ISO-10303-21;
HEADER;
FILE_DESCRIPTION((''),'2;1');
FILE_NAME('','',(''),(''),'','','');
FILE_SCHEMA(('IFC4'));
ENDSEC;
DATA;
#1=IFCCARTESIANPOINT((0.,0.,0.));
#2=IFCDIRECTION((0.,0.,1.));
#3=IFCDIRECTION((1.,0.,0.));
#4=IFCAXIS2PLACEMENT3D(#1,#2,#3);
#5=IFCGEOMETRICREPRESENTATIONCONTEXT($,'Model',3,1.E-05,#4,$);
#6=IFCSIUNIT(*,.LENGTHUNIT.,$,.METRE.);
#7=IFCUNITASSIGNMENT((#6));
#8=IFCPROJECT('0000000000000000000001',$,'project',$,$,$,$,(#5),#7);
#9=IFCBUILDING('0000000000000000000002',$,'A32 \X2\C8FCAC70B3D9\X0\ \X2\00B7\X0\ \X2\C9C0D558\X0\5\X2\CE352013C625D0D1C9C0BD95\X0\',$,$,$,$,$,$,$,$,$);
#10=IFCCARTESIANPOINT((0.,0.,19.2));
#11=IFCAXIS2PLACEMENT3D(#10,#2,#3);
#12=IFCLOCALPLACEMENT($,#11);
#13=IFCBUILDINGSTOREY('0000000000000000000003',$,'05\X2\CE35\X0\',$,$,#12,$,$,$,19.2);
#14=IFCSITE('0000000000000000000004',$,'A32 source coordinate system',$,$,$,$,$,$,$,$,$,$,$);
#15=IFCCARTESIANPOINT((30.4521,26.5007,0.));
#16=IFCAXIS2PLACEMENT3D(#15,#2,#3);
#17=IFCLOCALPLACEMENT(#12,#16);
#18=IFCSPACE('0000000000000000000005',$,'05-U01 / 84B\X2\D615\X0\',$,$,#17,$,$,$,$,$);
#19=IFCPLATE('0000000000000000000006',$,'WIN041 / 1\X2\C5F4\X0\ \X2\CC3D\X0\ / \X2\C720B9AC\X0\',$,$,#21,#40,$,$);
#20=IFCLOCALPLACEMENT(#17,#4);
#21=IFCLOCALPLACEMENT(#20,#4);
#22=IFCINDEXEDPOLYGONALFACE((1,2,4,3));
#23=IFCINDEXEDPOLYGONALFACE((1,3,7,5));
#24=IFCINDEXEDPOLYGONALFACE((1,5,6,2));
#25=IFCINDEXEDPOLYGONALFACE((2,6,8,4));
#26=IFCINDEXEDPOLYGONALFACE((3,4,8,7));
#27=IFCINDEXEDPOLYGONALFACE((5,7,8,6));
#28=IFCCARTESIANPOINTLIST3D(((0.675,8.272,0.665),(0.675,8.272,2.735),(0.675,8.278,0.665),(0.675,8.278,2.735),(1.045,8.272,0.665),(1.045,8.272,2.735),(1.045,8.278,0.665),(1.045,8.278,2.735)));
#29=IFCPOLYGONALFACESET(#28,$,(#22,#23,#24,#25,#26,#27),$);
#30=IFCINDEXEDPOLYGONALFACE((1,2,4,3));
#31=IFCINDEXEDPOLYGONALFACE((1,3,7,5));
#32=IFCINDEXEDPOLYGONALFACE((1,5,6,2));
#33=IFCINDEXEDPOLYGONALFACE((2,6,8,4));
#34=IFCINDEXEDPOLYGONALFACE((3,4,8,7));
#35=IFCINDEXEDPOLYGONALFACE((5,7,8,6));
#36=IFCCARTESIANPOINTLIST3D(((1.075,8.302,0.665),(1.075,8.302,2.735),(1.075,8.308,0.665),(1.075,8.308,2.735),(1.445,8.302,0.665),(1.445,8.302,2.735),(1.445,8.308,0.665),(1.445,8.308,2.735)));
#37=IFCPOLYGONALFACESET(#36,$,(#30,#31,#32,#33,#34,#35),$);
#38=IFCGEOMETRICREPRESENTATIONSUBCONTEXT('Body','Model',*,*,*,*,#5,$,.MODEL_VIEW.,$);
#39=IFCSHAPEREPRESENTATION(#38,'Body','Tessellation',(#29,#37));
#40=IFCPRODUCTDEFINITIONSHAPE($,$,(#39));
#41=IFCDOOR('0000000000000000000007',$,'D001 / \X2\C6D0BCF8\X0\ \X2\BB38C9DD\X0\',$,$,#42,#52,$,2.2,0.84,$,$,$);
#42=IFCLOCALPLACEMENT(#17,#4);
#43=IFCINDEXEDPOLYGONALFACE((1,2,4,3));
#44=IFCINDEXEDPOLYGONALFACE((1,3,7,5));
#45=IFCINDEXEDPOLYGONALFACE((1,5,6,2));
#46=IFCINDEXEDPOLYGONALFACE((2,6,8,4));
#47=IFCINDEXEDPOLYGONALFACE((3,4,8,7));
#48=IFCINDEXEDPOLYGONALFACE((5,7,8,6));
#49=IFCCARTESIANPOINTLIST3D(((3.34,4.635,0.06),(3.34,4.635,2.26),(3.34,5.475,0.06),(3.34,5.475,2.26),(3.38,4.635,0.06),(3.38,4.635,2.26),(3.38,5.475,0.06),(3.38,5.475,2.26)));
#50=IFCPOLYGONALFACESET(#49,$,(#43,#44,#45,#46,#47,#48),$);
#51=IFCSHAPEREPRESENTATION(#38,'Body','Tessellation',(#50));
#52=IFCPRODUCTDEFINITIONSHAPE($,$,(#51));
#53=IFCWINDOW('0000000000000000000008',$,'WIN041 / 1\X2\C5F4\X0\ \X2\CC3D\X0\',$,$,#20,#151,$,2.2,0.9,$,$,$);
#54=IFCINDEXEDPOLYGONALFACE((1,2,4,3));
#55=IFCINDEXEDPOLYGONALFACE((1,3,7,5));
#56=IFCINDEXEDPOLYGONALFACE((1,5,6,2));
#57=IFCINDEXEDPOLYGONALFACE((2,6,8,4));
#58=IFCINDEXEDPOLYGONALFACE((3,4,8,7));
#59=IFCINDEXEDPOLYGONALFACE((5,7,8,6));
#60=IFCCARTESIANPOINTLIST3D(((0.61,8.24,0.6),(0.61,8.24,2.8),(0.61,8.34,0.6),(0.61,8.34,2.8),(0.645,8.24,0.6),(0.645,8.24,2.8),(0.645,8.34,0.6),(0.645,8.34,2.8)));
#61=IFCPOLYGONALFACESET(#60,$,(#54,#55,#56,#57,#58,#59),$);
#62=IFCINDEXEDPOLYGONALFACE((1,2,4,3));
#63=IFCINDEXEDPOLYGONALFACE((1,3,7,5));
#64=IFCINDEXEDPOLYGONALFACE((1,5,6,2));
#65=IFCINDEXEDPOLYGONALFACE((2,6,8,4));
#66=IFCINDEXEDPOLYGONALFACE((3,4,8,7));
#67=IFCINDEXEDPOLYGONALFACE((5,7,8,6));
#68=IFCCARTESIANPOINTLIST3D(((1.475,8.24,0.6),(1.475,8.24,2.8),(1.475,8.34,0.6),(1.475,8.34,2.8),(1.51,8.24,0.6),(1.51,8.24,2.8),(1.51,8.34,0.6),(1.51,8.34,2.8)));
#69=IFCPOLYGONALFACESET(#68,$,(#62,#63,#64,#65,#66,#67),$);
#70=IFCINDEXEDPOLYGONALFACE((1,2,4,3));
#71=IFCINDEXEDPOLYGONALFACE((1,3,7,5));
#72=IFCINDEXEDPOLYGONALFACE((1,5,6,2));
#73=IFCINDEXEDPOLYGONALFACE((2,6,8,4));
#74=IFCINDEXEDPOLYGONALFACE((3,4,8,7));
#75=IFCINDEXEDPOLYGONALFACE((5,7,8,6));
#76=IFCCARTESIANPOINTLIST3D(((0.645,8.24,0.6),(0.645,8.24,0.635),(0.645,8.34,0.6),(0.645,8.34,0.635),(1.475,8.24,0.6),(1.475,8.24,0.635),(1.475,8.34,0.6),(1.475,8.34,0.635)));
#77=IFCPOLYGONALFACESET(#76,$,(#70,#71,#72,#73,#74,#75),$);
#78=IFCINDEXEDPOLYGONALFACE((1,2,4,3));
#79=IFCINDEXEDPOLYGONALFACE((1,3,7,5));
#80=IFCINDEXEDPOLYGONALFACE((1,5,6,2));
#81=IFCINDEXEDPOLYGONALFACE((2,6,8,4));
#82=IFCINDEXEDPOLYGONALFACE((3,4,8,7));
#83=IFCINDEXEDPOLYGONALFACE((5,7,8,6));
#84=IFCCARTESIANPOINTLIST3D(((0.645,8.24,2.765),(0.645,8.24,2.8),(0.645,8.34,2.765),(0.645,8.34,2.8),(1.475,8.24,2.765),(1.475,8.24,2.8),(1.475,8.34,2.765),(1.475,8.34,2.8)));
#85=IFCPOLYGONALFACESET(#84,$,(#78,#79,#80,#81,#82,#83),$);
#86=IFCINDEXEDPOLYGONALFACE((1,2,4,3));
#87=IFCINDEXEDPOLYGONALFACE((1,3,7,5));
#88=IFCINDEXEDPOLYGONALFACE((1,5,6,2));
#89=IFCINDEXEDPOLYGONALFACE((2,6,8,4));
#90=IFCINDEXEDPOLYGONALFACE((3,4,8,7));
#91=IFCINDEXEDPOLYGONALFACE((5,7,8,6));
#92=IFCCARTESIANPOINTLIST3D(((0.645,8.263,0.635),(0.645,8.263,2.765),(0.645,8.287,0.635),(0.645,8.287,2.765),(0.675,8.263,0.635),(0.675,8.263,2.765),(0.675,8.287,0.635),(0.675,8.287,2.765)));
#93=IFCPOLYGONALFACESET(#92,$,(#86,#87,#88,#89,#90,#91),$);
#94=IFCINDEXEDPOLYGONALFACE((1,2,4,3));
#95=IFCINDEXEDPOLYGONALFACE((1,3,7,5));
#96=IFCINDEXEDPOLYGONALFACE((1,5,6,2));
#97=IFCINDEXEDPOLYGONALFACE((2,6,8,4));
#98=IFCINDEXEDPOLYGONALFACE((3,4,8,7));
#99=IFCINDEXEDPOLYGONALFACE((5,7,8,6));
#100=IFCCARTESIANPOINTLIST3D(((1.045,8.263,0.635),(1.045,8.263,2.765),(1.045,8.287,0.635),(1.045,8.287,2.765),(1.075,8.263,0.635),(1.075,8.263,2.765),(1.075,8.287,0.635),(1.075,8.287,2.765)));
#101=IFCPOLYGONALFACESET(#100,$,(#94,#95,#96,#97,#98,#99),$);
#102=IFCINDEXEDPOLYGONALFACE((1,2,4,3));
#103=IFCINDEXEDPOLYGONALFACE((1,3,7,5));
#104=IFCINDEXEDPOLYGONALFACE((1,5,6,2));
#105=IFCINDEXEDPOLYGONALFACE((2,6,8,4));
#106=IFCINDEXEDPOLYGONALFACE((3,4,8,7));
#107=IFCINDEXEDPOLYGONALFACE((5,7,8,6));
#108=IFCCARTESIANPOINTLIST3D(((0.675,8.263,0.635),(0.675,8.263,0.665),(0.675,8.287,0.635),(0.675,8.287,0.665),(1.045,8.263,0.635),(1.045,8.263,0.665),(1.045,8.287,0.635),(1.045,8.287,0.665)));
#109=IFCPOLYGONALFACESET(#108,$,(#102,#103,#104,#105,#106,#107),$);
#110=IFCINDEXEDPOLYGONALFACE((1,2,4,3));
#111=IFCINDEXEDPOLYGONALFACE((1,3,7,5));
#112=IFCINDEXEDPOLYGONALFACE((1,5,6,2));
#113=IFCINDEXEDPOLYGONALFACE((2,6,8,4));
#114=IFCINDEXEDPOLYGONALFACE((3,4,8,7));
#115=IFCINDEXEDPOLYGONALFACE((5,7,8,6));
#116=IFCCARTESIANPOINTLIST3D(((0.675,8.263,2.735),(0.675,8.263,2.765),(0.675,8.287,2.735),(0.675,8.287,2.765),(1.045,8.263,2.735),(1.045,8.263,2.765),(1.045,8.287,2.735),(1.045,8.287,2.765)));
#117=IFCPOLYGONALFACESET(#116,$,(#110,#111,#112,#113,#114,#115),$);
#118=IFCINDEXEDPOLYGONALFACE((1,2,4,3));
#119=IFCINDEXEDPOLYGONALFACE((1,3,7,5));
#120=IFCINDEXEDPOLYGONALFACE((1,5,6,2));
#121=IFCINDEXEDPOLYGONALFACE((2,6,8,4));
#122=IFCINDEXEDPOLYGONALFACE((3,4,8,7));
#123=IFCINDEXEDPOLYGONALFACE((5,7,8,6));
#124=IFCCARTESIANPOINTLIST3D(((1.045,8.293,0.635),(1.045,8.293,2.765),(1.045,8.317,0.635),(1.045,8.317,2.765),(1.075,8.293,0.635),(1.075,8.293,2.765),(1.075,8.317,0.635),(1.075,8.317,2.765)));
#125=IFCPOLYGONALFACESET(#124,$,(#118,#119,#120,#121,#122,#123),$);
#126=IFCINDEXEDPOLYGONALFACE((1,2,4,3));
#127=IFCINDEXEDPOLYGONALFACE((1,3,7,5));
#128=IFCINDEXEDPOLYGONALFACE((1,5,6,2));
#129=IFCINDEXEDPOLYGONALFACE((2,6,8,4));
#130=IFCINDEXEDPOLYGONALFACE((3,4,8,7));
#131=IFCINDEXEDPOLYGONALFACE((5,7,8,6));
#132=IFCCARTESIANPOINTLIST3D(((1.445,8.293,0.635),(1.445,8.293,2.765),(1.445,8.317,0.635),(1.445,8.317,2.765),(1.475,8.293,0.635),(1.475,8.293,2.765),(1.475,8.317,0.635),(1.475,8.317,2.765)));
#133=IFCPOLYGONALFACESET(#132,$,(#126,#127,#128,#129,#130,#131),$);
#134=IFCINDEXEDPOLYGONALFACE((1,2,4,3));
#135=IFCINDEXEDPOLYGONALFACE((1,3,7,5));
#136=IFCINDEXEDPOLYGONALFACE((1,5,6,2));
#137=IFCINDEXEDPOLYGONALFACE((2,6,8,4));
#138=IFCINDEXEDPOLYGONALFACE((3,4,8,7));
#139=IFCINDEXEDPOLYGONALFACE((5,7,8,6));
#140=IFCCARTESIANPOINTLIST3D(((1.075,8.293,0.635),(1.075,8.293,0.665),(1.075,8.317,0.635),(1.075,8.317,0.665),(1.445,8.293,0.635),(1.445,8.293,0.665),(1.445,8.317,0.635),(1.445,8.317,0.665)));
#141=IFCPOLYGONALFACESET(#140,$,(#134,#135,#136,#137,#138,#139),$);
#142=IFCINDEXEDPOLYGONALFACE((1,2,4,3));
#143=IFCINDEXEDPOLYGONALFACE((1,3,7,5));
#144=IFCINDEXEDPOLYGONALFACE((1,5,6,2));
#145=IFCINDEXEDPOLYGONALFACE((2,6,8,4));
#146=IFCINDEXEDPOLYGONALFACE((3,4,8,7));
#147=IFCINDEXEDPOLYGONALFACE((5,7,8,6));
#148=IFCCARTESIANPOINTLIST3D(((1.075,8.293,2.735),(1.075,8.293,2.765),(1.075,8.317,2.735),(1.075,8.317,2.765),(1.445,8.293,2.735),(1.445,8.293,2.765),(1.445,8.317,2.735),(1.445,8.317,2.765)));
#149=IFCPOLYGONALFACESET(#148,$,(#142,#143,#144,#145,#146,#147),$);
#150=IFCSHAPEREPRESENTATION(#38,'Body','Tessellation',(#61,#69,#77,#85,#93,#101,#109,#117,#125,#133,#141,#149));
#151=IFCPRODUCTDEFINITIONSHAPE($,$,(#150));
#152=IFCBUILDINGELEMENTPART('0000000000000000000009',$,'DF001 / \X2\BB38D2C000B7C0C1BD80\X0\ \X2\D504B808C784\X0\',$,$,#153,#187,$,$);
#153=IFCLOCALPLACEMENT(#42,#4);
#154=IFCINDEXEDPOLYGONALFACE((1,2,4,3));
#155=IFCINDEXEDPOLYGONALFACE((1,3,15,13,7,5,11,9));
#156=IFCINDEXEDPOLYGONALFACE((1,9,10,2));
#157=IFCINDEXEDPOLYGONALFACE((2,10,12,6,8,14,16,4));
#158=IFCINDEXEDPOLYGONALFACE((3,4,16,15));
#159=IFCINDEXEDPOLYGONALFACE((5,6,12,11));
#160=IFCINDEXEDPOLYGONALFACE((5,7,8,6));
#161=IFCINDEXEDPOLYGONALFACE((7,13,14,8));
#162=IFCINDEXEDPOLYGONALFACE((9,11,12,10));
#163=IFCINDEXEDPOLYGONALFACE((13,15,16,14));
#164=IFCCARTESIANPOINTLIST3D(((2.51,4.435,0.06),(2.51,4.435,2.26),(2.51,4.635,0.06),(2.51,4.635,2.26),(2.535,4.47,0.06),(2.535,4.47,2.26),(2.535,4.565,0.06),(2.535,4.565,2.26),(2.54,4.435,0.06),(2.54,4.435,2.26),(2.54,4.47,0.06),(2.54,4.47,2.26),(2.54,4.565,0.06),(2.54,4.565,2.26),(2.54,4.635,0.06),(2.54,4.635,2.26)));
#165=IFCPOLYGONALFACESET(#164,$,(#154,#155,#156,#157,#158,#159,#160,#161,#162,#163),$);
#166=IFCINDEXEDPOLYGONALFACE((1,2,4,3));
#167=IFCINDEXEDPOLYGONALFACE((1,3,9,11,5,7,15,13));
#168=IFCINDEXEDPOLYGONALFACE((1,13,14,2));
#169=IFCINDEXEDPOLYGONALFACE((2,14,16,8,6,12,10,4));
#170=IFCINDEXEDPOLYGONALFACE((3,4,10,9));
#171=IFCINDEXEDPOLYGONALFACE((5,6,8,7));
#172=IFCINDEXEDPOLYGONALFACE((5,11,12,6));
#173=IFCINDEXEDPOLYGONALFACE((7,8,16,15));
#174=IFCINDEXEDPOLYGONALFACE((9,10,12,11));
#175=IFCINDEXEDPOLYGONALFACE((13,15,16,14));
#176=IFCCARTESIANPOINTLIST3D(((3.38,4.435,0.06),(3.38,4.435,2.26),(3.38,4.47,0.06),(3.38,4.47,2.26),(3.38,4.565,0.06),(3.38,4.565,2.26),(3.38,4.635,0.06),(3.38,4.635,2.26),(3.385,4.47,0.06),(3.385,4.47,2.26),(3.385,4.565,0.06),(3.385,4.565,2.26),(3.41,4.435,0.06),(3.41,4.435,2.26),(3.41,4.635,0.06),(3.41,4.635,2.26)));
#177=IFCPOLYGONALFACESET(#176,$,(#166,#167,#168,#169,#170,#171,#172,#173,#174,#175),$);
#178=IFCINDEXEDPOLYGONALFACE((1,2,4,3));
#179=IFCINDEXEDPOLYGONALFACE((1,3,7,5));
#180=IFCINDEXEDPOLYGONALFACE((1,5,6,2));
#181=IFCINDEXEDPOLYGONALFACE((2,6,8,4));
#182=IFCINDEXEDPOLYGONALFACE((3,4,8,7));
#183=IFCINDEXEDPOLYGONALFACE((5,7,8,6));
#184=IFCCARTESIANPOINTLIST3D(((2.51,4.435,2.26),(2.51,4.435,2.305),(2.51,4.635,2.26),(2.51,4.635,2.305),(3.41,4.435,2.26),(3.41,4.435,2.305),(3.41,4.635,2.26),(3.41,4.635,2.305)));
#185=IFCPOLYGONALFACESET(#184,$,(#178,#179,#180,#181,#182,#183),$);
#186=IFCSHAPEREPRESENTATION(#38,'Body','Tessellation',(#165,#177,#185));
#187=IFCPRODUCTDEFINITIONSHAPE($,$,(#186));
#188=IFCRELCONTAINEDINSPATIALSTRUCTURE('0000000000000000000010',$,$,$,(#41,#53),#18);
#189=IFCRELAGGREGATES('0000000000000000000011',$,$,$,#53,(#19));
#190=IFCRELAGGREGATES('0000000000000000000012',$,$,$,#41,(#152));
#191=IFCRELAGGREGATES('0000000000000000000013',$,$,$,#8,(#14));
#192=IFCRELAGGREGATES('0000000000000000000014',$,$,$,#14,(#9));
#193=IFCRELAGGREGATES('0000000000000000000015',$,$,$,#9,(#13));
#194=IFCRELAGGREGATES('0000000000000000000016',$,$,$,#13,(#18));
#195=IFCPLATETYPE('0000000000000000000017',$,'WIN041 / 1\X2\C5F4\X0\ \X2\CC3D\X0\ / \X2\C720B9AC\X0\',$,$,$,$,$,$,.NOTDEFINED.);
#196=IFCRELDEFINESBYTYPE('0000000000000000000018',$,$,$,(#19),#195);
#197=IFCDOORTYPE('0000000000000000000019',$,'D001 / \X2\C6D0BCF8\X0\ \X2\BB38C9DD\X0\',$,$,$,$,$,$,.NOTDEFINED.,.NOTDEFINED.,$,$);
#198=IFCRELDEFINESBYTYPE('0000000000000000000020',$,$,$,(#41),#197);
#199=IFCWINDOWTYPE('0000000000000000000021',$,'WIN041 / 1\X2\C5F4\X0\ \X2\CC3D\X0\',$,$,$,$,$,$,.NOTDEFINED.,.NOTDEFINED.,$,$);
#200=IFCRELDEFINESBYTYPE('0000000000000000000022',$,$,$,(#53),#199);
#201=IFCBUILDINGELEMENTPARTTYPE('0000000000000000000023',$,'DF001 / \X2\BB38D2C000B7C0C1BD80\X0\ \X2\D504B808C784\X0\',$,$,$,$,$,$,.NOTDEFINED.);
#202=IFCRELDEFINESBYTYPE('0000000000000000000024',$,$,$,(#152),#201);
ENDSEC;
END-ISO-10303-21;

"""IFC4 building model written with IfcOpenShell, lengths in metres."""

from ifc_helpers import new_model, si_unit, frame, origin, origin_with_axes, place, context, subcontext, project, spatial, polyline, outline, extrude, source, transform, mapped, type_object, type_shapes, element, aggregate, save


model = new_model("IFC4")

# Units and contexts
model_context = context("Model", 3, precision=1e-05, world=origin_with_axes())
body_context = subcontext(model_context, "Body", "Model", "MODEL_VIEW")
ifc_project = project(units=[si_unit("LENGTHUNIT", "METRE")], contexts=[model_context])

# Plate
storey_placement = place(None, frame((0.0, 0.0, 19.2), z_axis=(0.0, 0.0, 1.0), x_axis=(1.0, 0.0, 0.0)))
space_placement = place(storey_placement, frame((30.4521, 26.5007, 0.0), z_axis=(0.0, 0.0, 1.0), x_axis=(1.0, 0.0, 0.0)))
plate_type_1 = type_object("IfcPlateType", Name="WIN041 / 1열 창 / 유리", PredefinedType="NOTDEFINED")
shared_shape_1 = source(origin(), body_context, "Body", "SweptSolid", [
    extrude(outline(polyline([(0.675, 8.272), (0.675, 8.278), (1.045, 8.278), (1.045, 8.272), (0.675, 8.272)])), frame((0.0, 0.0, 0.665)), (0.0, 0.0, 1.0), 2.07),
    extrude(outline(polyline([(1.075, 8.302), (1.075, 8.308), (1.445, 8.308), (1.445, 8.302), (1.075, 8.302)])), frame((0.0, 0.0, 0.665)), (0.0, 0.0, 1.0), 2.07),
])
type_shapes(plate_type_1, [shared_shape_1])
window_1_placement = place(space_placement, origin_with_axes())
plate_1_placement = place(window_1_placement, origin_with_axes())
plate_1 = element("IfcPlate", 1, at=plate_1_placement, type_object=plate_type_1, Name="WIN041 / 1열 창 / 유리", context=body_context, shape_type="MappedRepresentation", body=[
    mapped(shared_shape_1, transform((0.0, 0.0, 0.0), scale=1.0)),
])

# Site, building, storey, space
site = spatial("IfcSite", under=ifc_project, Name="A32 source coordinate system")
building = spatial("IfcBuilding", under=site, Name="A32 주거동 · 지하5층–옥탑지붕")
storey = spatial("IfcBuildingStorey", under=building, at=storey_placement, Name="05층", Elevation=19.2)
space = spatial("IfcSpace", under=storey, at=space_placement, Name="05-U01 / 84B형")

# Door
door_type_1 = type_object("IfcDoorType", Name="D001 / 원본 문짝", OperationType="NOTDEFINED", PredefinedType="NOTDEFINED")
shared_shape_2 = source(origin(), body_context, "Body", "SweptSolid", [
    extrude(outline(polyline([(3.34, 5.475), (3.38, 5.475), (3.38, 4.635), (3.34, 4.635), (3.34, 5.475)])), frame((0.0, 0.0, 0.06)), (0.0, 0.0, 1.0), 2.2),
])
type_shapes(door_type_1, [shared_shape_2])
door_1_placement = place(space_placement, origin_with_axes())
door_1 = element("IfcDoor", 2, at=door_1_placement, inside=space, type_object=door_type_1, Name="D001 / 원본 문짝", OverallHeight=2.2, OverallWidth=0.84, context=body_context, shape_type="MappedRepresentation", body=[
    mapped(shared_shape_2, transform((0.0, 0.0, 0.0), scale=1.0)),
])

# Window
window_type_1 = type_object("IfcWindowType", Name="WIN041 / 1열 창", PartitioningType="NOTDEFINED", PredefinedType="NOTDEFINED")
shared_shape_3 = source(origin(), body_context, "Body", "SweptSolid", [
    extrude(outline(polyline([(0.61, 8.24), (0.61, 8.34), (0.645, 8.34), (0.645, 8.24), (0.61, 8.24)])), frame((0.0, 0.0, 0.6)), (0.0, 0.0, 1.0), 2.2),
    extrude(outline(polyline([(1.475, 8.24), (1.475, 8.34), (1.51, 8.34), (1.51, 8.24), (1.475, 8.24)])), frame((0.0, 0.0, 0.6)), (0.0, 0.0, 1.0), 2.2),
    extrude(outline(polyline([(0.645, 8.24), (0.645, 8.34), (1.475, 8.34), (1.475, 8.24), (0.645, 8.24)])), frame((0.0, 0.0, 0.6)), (0.0, 0.0, 1.0), 0.035),
    extrude(outline(polyline([(0.645, 8.24), (0.645, 8.34), (1.475, 8.34), (1.475, 8.24), (0.645, 8.24)])), frame((0.0, 0.0, 2.765)), (0.0, 0.0, 1.0), 0.035),
    extrude(outline(polyline([(0.645, 8.263), (0.645, 8.287), (0.675, 8.287), (0.675, 8.263), (0.645, 8.263)])), frame((0.0, 0.0, 0.635)), (0.0, 0.0, 1.0), 2.13),
    extrude(outline(polyline([(1.045, 8.263), (1.045, 8.287), (1.075, 8.287), (1.075, 8.263), (1.045, 8.263)])), frame((0.0, 0.0, 0.635)), (0.0, 0.0, 1.0), 2.13),
    extrude(outline(polyline([(0.675, 8.263), (0.675, 8.287), (1.045, 8.287), (1.045, 8.263), (0.675, 8.263)])), frame((0.0, 0.0, 0.635)), (0.0, 0.0, 1.0), 0.03),
    extrude(outline(polyline([(0.675, 8.263), (0.675, 8.287), (1.045, 8.287), (1.045, 8.263), (0.675, 8.263)])), frame((0.0, 0.0, 2.735)), (0.0, 0.0, 1.0), 0.03),
    extrude(outline(polyline([(1.045, 8.293), (1.045, 8.317), (1.075, 8.317), (1.075, 8.293), (1.045, 8.293)])), frame((0.0, 0.0, 0.635)), (0.0, 0.0, 1.0), 2.13),
    extrude(outline(polyline([(1.445, 8.293), (1.445, 8.317), (1.475, 8.317), (1.475, 8.293), (1.445, 8.293)])), frame((0.0, 0.0, 0.635)), (0.0, 0.0, 1.0), 2.13),
    extrude(outline(polyline([(1.075, 8.293), (1.075, 8.317), (1.445, 8.317), (1.445, 8.293), (1.075, 8.293)])), frame((0.0, 0.0, 0.635)), (0.0, 0.0, 1.0), 0.03),
    extrude(outline(polyline([(1.075, 8.293), (1.075, 8.317), (1.445, 8.317), (1.445, 8.293), (1.075, 8.293)])), frame((0.0, 0.0, 2.735)), (0.0, 0.0, 1.0), 0.03),
])
type_shapes(window_type_1, [shared_shape_3])
window_1 = element("IfcWindow", 3, at=window_1_placement, inside=space, type_object=window_type_1, Name="WIN041 / 1열 창", OverallHeight=2.2, OverallWidth=0.9, context=body_context, shape_type="MappedRepresentation", body=[
    mapped(shared_shape_3, transform((0.0, 0.0, 0.0), scale=1.0)),
])
aggregate(window_1, [plate_1])

# Building element part
building_element_part_type_1 = type_object("IfcBuildingElementPartType", Name="DF001 / 문틀·상부 프레임", PredefinedType="NOTDEFINED")
shared_shape_4 = source(origin(), body_context, "Body", "SweptSolid", [
    extrude(outline(polyline([(2.54, 4.635), (2.54, 4.565), (2.535, 4.565), (2.535, 4.47), (2.54, 4.47), (2.54, 4.435), (2.51, 4.435), (2.51, 4.635), (2.54, 4.635)])), frame((0.0, 0.0, 0.06)), (0.0, 0.0, 1.0), 2.2),
    extrude(outline(polyline([(3.41, 4.435), (3.38, 4.435), (3.38, 4.47), (3.385, 4.47), (3.385, 4.565), (3.38, 4.565), (3.38, 4.635), (3.41, 4.635), (3.41, 4.435)])), frame((0.0, 0.0, 0.06)), (0.0, 0.0, 1.0), 2.2),
    extrude(outline(polyline([(2.51, 4.435), (2.51, 4.635), (3.41, 4.635), (3.41, 4.435), (2.51, 4.435)])), frame((0.0, 0.0, 2.26)), (0.0, 0.0, 1.0), 0.045),
])
type_shapes(building_element_part_type_1, [shared_shape_4])
building_element_part_1_placement = place(door_1_placement, origin_with_axes())
building_element_part_1 = element("IfcBuildingElementPart", 4, at=building_element_part_1_placement, type_object=building_element_part_type_1, Name="DF001 / 문틀·상부 프레임", context=body_context, shape_type="MappedRepresentation", body=[
    mapped(shared_shape_4, transform((0.0, 0.0, 0.0), scale=1.0)),
])
aggregate(door_1, [building_element_part_1])

save(model, "model.ifc")
